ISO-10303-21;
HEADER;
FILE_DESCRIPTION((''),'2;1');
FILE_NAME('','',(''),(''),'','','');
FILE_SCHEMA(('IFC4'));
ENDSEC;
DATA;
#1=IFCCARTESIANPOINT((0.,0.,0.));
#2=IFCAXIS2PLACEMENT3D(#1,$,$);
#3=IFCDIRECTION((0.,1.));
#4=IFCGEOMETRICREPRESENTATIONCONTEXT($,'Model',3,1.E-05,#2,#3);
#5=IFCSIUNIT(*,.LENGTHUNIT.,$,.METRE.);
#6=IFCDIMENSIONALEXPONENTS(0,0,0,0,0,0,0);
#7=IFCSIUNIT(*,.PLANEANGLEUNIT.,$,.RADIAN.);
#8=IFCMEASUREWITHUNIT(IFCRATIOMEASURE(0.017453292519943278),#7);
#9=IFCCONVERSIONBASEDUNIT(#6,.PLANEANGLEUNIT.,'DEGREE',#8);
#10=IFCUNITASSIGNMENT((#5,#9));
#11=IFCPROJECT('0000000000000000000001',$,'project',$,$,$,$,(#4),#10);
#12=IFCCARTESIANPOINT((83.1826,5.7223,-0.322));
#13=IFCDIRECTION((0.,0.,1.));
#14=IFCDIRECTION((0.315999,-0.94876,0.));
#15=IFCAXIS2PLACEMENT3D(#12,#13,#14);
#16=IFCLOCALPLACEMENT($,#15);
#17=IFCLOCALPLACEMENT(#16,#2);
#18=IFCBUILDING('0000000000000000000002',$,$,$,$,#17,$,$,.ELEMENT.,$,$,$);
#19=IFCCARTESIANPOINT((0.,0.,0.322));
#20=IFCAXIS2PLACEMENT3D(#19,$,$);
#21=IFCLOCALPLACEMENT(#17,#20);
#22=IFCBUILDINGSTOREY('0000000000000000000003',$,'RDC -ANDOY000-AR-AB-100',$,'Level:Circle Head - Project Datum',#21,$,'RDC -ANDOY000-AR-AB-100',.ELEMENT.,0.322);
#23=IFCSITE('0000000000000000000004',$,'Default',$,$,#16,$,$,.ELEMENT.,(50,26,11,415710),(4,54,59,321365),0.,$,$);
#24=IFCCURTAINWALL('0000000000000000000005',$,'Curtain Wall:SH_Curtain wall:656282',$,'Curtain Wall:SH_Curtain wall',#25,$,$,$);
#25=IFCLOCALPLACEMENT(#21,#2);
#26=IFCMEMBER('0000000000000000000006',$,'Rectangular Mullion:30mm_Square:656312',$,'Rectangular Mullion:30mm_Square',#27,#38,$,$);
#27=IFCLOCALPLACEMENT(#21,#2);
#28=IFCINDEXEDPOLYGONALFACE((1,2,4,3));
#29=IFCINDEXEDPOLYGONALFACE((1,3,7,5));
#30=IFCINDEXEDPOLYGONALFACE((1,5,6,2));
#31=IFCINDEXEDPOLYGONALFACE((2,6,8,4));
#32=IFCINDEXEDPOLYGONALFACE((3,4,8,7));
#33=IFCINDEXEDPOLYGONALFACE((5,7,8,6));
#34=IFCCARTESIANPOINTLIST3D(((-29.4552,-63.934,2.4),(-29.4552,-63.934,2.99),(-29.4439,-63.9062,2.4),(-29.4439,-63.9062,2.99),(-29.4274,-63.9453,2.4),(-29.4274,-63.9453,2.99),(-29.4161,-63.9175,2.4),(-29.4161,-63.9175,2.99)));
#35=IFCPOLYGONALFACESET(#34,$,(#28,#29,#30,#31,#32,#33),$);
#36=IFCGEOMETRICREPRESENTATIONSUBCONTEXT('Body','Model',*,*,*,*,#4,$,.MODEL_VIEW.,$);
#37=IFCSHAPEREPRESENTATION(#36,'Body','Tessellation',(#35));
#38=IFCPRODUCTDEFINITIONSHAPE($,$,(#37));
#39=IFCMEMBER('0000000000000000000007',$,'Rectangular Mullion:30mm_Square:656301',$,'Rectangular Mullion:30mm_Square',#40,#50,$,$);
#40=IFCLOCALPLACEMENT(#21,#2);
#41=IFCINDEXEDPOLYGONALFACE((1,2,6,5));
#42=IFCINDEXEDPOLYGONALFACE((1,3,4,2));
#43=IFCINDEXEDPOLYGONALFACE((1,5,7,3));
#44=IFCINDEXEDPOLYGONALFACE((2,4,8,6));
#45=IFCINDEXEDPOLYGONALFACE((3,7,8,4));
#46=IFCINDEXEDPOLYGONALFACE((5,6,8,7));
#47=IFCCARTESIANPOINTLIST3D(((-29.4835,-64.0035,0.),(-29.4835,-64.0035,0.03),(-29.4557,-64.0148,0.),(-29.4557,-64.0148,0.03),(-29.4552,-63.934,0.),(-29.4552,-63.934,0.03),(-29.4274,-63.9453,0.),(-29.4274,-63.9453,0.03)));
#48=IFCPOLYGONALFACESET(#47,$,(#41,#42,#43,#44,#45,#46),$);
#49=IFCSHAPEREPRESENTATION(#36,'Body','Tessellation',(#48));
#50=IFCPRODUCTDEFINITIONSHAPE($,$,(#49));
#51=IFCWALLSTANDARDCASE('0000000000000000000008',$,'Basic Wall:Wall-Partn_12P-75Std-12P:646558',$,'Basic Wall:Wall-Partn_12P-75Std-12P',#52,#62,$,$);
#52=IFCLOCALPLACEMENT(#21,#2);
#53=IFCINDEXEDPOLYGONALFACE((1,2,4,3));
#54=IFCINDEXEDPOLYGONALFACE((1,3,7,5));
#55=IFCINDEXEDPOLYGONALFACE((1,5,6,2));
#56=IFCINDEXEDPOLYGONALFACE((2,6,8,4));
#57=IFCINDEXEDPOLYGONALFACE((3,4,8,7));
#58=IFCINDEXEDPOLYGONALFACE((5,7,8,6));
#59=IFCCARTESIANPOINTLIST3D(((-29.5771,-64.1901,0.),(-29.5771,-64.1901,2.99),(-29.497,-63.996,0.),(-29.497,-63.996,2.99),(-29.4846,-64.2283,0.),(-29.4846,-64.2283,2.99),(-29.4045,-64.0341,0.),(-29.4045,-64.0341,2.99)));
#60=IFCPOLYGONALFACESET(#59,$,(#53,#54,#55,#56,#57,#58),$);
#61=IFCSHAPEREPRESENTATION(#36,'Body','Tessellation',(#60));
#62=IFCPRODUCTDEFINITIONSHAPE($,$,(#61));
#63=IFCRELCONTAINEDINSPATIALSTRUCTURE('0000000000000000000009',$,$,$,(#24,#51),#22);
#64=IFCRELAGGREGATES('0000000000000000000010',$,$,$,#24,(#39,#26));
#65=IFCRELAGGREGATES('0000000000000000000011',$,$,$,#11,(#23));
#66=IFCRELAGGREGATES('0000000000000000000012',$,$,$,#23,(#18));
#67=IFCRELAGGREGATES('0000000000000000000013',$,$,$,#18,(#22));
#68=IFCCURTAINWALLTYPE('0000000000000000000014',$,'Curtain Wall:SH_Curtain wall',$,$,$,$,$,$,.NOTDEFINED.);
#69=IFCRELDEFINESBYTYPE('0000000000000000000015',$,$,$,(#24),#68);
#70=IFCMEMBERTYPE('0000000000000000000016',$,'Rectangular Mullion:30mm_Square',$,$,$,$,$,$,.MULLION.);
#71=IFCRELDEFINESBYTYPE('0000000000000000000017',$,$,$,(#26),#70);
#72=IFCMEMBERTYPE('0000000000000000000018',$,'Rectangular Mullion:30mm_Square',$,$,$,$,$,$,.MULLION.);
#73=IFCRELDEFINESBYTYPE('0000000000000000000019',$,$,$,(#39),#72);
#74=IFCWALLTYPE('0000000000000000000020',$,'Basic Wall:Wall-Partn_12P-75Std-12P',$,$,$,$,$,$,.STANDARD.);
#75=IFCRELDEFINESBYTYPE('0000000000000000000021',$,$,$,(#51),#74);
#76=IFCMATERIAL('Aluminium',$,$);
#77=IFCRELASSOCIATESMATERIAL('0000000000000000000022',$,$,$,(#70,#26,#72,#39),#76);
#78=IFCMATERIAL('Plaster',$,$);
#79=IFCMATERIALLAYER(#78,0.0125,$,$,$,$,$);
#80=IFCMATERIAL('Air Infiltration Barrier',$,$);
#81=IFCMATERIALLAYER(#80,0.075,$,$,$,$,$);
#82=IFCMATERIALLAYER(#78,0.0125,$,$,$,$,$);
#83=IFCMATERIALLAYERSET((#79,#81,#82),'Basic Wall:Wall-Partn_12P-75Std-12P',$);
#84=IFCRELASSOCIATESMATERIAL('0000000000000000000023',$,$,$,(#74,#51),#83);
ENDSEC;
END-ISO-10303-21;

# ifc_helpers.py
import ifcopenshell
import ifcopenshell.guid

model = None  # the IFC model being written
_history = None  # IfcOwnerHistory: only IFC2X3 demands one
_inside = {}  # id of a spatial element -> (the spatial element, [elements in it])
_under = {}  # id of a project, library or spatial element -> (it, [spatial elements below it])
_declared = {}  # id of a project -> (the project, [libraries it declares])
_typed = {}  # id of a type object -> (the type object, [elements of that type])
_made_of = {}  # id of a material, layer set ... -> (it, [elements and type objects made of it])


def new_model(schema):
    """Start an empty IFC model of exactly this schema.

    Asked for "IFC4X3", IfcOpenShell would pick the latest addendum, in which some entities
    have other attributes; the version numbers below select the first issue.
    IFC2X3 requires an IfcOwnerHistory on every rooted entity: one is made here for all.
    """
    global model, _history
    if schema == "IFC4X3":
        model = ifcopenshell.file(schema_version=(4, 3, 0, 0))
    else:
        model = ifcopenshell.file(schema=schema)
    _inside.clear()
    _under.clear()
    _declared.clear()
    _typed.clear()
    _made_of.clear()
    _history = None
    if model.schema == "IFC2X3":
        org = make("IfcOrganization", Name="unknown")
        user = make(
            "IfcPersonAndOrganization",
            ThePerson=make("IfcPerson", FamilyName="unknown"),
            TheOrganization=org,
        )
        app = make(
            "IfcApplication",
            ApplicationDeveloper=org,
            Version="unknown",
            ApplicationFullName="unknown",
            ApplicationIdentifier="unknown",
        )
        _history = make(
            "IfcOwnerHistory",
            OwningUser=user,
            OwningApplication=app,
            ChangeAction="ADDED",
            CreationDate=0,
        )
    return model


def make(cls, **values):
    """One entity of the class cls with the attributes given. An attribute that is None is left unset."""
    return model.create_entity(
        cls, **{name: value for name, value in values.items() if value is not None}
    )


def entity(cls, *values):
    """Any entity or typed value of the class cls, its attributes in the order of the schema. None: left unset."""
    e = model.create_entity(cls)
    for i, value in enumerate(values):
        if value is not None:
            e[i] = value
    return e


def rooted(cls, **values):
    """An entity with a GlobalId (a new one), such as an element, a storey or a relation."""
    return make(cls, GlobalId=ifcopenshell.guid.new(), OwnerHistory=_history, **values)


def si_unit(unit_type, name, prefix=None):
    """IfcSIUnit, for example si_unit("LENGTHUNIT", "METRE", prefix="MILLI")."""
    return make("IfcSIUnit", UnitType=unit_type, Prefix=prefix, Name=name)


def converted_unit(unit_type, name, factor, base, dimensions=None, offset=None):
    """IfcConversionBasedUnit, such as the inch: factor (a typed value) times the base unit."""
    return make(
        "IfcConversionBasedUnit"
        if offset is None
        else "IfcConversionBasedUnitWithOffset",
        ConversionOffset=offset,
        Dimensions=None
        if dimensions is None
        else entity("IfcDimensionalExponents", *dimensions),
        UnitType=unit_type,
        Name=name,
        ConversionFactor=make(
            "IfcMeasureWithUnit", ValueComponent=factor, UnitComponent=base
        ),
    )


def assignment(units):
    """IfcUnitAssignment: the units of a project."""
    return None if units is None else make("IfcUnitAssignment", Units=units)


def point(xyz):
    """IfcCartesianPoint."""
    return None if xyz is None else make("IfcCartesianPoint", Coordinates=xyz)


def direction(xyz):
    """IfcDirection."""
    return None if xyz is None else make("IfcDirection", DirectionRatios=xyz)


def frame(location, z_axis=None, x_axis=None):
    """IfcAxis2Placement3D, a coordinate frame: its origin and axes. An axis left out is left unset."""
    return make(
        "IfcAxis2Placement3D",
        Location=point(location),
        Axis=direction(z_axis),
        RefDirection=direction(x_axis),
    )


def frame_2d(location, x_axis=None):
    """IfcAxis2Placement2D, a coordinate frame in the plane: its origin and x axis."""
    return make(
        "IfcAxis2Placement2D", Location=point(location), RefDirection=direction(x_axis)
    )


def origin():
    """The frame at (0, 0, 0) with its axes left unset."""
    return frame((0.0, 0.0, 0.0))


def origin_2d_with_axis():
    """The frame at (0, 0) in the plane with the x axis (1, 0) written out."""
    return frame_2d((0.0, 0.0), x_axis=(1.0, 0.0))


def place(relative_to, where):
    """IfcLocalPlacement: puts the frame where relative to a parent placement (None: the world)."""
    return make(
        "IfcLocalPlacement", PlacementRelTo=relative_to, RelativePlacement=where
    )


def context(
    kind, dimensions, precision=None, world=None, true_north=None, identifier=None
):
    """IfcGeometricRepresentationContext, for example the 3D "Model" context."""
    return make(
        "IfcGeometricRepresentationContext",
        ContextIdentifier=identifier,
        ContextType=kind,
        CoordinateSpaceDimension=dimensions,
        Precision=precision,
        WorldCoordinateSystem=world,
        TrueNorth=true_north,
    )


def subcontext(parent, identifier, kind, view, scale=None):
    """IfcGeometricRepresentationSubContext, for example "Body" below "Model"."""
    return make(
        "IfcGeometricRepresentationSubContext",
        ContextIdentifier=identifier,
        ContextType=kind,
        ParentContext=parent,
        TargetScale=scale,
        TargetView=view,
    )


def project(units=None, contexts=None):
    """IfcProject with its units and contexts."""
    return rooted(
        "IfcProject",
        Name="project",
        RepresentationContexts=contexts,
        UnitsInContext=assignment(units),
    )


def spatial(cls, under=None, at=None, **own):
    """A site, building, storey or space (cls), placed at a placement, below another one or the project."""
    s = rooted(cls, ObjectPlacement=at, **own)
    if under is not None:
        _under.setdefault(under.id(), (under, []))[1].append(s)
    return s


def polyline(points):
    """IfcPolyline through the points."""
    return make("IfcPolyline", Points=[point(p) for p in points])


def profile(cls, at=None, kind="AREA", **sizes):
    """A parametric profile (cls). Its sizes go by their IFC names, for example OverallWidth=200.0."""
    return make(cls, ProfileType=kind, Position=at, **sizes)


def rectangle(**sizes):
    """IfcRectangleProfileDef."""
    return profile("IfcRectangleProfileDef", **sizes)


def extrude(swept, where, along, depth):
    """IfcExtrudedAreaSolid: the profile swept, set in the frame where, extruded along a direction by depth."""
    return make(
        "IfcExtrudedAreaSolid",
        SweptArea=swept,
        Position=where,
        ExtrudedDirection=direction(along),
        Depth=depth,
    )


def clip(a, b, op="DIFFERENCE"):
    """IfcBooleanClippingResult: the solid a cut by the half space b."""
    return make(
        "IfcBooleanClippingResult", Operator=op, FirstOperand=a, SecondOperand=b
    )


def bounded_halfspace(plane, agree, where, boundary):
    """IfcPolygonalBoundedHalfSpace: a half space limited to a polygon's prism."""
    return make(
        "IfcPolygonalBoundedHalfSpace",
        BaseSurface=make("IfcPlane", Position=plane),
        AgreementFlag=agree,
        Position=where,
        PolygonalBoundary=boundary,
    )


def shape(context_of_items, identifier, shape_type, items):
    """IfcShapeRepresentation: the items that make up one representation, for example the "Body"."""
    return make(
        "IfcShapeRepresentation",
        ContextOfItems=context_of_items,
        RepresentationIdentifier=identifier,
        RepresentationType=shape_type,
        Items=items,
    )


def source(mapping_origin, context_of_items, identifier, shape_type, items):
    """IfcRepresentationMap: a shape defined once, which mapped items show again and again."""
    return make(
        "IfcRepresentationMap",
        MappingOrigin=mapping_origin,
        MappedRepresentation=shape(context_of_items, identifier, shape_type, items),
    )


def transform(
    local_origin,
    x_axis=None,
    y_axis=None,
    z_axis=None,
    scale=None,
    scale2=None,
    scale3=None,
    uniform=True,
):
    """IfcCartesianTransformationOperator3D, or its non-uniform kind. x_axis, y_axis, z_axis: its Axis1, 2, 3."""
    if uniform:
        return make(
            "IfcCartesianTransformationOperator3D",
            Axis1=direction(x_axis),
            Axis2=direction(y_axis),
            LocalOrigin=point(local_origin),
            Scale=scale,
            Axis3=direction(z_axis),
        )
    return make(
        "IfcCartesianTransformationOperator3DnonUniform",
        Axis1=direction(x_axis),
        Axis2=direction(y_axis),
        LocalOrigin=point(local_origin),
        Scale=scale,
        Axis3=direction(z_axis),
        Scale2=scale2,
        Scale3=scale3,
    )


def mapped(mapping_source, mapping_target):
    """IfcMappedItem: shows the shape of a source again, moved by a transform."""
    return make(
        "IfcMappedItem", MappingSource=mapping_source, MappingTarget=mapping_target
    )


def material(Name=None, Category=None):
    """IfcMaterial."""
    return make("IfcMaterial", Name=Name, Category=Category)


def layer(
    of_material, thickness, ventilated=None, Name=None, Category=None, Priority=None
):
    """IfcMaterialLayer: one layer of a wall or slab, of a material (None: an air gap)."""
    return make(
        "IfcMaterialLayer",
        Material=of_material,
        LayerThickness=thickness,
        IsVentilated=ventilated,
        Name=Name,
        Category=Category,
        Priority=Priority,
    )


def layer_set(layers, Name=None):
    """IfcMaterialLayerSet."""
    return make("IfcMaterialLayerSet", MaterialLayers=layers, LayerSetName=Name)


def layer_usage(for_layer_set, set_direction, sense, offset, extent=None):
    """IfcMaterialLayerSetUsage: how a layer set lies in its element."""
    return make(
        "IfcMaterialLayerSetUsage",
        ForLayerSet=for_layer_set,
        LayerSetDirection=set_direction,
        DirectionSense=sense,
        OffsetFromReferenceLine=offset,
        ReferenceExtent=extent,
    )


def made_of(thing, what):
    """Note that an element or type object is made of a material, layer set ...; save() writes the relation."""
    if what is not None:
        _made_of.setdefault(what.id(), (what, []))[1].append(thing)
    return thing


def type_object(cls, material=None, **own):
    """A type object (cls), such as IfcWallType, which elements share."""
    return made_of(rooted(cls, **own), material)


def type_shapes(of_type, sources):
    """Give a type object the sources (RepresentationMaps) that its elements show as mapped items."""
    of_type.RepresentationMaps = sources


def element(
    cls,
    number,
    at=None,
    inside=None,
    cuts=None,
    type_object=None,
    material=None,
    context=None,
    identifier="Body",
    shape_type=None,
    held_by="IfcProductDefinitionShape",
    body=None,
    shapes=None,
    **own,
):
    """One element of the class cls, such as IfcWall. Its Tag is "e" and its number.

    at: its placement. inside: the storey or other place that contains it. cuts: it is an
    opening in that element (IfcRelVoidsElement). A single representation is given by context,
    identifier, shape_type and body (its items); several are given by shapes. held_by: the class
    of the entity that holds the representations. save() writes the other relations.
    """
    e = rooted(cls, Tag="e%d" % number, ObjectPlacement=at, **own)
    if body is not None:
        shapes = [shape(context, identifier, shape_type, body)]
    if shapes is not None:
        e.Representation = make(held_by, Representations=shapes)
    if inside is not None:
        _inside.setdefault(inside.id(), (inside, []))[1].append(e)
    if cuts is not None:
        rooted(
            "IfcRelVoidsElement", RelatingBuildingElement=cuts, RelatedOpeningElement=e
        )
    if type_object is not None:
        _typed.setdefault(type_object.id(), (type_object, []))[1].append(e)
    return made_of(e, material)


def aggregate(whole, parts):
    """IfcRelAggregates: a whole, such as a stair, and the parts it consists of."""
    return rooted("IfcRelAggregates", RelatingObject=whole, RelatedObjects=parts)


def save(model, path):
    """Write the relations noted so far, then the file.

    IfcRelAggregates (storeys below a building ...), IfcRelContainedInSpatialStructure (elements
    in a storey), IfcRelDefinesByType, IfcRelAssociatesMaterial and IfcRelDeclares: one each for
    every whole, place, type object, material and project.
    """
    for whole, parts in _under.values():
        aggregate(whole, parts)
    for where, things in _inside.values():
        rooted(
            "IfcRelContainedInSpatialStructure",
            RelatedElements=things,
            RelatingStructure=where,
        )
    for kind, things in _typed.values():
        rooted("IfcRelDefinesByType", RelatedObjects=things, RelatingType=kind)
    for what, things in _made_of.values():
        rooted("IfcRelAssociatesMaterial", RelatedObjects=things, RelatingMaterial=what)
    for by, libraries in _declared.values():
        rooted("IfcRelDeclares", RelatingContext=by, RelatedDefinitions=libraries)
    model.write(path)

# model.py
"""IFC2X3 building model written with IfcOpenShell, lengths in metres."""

from ifc_helpers import new_model, entity, si_unit, converted_unit, direction, frame, frame_2d, origin, origin_2d_with_axis, place, context, subcontext, project, spatial, polyline, rectangle, extrude, clip, bounded_halfspace, source, transform, mapped, material, layer, layer_set, layer_usage, type_object, type_shapes, element, aggregate, save


model = new_model("IFC2X3")

# Units and contexts
model_context = context("Model", 3, precision=1e-05, world=origin(), true_north=direction((0.0, 1.0)))
body_context = subcontext(model_context, "Body", "Model", "MODEL_VIEW")
ifc_project = project(units=[si_unit("LENGTHUNIT", "METRE"), converted_unit("PLANEANGLEUNIT", "DEGREE", entity("IfcRatioMeasure", 0.017453292519943278), si_unit("PLANEANGLEUNIT", "RADIAN"), dimensions=[0, 0, 0, 0, 0, 0, 0])], contexts=[model_context])

# Site, building, storey
site_placement = place(None, frame((83.1826, 5.7223, -0.322), z_axis=(0.0, 0.0, 1.0), x_axis=(0.315999, -0.94876, 0.0)))
site = spatial("IfcSite", under=ifc_project, at=site_placement, Name="Default", CompositionType="ELEMENT", RefLatitude=(50, 26, 11, 415710), RefLongitude=(4, 54, 59, 321365), RefElevation=0.0)
building_placement = place(site_placement, origin())
building = spatial("IfcBuilding", under=site, at=building_placement, CompositionType="ELEMENT")
storey_placement = place(building_placement, frame((0.0, 0.0, 0.322)))
storey = spatial("IfcBuildingStorey", under=building, at=storey_placement, Name="RDC -ANDOY000-AR-AB-100", ObjectType="Level:Circle Head - Project Datum", LongName="RDC -ANDOY000-AR-AB-100", CompositionType="ELEMENT", Elevation=0.322)

# Shared definitions
curtain_wall_type = type_object("IfcCurtainWallType", Name="Curtain Wall:SH_Curtain wall", PredefinedType="NOTDEFINED")
ifc_material_1 = material(Name="Aluminium")

# Curtain wall
curtain_wall_1_placement = place(storey_placement, frame((0.0, 0.0, -0.322)))
curtain_wall_1 = element("IfcCurtainWall", 1, at=curtain_wall_1_placement, inside=storey, type_object=curtain_wall_type, Name="Curtain Wall:SH_Curtain wall:656282", ObjectType="Curtain Wall:SH_Curtain wall")

# Members
member_type_1 = type_object("IfcMemberType", Name="Rectangular Mullion:30mm_Square", PredefinedType="MULLION", material=ifc_material_1)
shared_shape_1 = source(origin(), body_context, "Body", "SweptSolid", [
    extrude(rectangle(XDim=0.03, YDim=0.03, at=origin_2d_with_axis()), frame((0.0, 0.0, -0.59), z_axis=(0.0, 0.0, 1.0), x_axis=(0.0, -1.0, 0.0)), (0.0, 0.0, 1.0), 0.59),
])
type_shapes(member_type_1, [shared_shape_1])
member_1_placement = place(curtain_wall_1_placement, frame((-29.4356, -63.9258, 2.722), z_axis=(0.0, 0.0, -1.0), x_axis=(-0.377092, -0.926176, 0.0)))
member_1 = element("IfcMember", 2, at=member_1_placement, type_object=member_type_1, material=ifc_material_1, Name="Rectangular Mullion:30mm_Square:656312", ObjectType="Rectangular Mullion:30mm_Square", context=body_context, shape_type="MappedRepresentation", body=[
    mapped(shared_shape_1, transform((0.0, 0.0, 0.0), scale=1.0)),
])
member_type_2 = type_object("IfcMemberType", Name="Rectangular Mullion:30mm_Square", PredefinedType="MULLION", material=ifc_material_1)
shared_shape_2 = source(origin(), body_context, "Body", "SweptSolid", [
    extrude(rectangle(XDim=0.03, YDim=0.03, at=origin_2d_with_axis()), frame((-0.015, 0.0, -0.075), z_axis=(0.0, 0.0, 1.0), x_axis=(0.0, -1.0, 0.0)), (0.0, 0.0, 1.0), 0.075),
])
type_shapes(member_type_2, [shared_shape_2])
member_2_placement = place(curtain_wall_1_placement, frame((-29.4413, -63.9396, 0.322), z_axis=(0.377092, 0.926176, 0.0), x_axis=(0.0, 0.0, -1.0)))
member_2 = element("IfcMember", 3, at=member_2_placement, type_object=member_type_2, material=ifc_material_1, Name="Rectangular Mullion:30mm_Square:656301", ObjectType="Rectangular Mullion:30mm_Square", context=body_context, shape_type="MappedRepresentation", body=[
    mapped(shared_shape_2, transform((0.0, 0.0, 0.0), scale=1.0)),
])

aggregate(curtain_wall_1, [member_2, member_1])

# Wall
ifc_material_2 = material(Name="Plaster")
ifc_layer_1 = layer(ifc_material_2, 0.0125)
ifc_material_3 = material(Name="Air Infiltration Barrier")
ifc_layer_2 = layer(ifc_material_3, 0.075)
ifc_layer_3 = layer(ifc_material_2, 0.0125)
ifc_layer_set = layer_set([ifc_layer_1, ifc_layer_2, ifc_layer_3], Name="Basic Wall:Wall-Partn_12P-75Std-12P")
ifc_layer_usage = layer_usage(ifc_layer_set, "AXIS2", "NEGATIVE", 0.05)
wall_type = type_object("IfcWallType", Name="Basic Wall:Wall-Partn_12P-75Std-12P", PredefinedType="STANDARD", material=ifc_layer_set)
wall_placement = place(storey_placement, frame((-29.5309, -64.2092, 0.0), z_axis=(0.0, 0.0, 1.0), x_axis=(0.381413, 0.924405, 0.0)))
element("IfcWallStandardCase", 4, at=wall_placement, inside=storey, type_object=wall_type, material=ifc_layer_usage, Name="Basic Wall:Wall-Partn_12P-75Std-12P:646558", ObjectType="Basic Wall:Wall-Partn_12P-75Std-12P", context=body_context, shape_type="Clipping", body=[
    clip(extrude(rectangle(XDim=0.21, YDim=0.1, at=frame_2d((0.105, 0.0), x_axis=(-1.0, 0.0))), origin(), (0.0, 0.0, 1.0), 2.99), bounded_halfspace(frame((0.0, -0.05, 2.99), z_axis=(0.0, 0.0, -1.0), x_axis=(0.069756, -0.997564, 0.0)), True, frame((0.0, -0.05, 2.99)), polyline([(0.0, 0.0), (0.048, 0.0), (0.1482, 0.0), (0.21, 0.0), (0.21, 0.1), (0.0, 0.1), (0.0, 0.0)]))),
])

save(model, "model.ifc")
